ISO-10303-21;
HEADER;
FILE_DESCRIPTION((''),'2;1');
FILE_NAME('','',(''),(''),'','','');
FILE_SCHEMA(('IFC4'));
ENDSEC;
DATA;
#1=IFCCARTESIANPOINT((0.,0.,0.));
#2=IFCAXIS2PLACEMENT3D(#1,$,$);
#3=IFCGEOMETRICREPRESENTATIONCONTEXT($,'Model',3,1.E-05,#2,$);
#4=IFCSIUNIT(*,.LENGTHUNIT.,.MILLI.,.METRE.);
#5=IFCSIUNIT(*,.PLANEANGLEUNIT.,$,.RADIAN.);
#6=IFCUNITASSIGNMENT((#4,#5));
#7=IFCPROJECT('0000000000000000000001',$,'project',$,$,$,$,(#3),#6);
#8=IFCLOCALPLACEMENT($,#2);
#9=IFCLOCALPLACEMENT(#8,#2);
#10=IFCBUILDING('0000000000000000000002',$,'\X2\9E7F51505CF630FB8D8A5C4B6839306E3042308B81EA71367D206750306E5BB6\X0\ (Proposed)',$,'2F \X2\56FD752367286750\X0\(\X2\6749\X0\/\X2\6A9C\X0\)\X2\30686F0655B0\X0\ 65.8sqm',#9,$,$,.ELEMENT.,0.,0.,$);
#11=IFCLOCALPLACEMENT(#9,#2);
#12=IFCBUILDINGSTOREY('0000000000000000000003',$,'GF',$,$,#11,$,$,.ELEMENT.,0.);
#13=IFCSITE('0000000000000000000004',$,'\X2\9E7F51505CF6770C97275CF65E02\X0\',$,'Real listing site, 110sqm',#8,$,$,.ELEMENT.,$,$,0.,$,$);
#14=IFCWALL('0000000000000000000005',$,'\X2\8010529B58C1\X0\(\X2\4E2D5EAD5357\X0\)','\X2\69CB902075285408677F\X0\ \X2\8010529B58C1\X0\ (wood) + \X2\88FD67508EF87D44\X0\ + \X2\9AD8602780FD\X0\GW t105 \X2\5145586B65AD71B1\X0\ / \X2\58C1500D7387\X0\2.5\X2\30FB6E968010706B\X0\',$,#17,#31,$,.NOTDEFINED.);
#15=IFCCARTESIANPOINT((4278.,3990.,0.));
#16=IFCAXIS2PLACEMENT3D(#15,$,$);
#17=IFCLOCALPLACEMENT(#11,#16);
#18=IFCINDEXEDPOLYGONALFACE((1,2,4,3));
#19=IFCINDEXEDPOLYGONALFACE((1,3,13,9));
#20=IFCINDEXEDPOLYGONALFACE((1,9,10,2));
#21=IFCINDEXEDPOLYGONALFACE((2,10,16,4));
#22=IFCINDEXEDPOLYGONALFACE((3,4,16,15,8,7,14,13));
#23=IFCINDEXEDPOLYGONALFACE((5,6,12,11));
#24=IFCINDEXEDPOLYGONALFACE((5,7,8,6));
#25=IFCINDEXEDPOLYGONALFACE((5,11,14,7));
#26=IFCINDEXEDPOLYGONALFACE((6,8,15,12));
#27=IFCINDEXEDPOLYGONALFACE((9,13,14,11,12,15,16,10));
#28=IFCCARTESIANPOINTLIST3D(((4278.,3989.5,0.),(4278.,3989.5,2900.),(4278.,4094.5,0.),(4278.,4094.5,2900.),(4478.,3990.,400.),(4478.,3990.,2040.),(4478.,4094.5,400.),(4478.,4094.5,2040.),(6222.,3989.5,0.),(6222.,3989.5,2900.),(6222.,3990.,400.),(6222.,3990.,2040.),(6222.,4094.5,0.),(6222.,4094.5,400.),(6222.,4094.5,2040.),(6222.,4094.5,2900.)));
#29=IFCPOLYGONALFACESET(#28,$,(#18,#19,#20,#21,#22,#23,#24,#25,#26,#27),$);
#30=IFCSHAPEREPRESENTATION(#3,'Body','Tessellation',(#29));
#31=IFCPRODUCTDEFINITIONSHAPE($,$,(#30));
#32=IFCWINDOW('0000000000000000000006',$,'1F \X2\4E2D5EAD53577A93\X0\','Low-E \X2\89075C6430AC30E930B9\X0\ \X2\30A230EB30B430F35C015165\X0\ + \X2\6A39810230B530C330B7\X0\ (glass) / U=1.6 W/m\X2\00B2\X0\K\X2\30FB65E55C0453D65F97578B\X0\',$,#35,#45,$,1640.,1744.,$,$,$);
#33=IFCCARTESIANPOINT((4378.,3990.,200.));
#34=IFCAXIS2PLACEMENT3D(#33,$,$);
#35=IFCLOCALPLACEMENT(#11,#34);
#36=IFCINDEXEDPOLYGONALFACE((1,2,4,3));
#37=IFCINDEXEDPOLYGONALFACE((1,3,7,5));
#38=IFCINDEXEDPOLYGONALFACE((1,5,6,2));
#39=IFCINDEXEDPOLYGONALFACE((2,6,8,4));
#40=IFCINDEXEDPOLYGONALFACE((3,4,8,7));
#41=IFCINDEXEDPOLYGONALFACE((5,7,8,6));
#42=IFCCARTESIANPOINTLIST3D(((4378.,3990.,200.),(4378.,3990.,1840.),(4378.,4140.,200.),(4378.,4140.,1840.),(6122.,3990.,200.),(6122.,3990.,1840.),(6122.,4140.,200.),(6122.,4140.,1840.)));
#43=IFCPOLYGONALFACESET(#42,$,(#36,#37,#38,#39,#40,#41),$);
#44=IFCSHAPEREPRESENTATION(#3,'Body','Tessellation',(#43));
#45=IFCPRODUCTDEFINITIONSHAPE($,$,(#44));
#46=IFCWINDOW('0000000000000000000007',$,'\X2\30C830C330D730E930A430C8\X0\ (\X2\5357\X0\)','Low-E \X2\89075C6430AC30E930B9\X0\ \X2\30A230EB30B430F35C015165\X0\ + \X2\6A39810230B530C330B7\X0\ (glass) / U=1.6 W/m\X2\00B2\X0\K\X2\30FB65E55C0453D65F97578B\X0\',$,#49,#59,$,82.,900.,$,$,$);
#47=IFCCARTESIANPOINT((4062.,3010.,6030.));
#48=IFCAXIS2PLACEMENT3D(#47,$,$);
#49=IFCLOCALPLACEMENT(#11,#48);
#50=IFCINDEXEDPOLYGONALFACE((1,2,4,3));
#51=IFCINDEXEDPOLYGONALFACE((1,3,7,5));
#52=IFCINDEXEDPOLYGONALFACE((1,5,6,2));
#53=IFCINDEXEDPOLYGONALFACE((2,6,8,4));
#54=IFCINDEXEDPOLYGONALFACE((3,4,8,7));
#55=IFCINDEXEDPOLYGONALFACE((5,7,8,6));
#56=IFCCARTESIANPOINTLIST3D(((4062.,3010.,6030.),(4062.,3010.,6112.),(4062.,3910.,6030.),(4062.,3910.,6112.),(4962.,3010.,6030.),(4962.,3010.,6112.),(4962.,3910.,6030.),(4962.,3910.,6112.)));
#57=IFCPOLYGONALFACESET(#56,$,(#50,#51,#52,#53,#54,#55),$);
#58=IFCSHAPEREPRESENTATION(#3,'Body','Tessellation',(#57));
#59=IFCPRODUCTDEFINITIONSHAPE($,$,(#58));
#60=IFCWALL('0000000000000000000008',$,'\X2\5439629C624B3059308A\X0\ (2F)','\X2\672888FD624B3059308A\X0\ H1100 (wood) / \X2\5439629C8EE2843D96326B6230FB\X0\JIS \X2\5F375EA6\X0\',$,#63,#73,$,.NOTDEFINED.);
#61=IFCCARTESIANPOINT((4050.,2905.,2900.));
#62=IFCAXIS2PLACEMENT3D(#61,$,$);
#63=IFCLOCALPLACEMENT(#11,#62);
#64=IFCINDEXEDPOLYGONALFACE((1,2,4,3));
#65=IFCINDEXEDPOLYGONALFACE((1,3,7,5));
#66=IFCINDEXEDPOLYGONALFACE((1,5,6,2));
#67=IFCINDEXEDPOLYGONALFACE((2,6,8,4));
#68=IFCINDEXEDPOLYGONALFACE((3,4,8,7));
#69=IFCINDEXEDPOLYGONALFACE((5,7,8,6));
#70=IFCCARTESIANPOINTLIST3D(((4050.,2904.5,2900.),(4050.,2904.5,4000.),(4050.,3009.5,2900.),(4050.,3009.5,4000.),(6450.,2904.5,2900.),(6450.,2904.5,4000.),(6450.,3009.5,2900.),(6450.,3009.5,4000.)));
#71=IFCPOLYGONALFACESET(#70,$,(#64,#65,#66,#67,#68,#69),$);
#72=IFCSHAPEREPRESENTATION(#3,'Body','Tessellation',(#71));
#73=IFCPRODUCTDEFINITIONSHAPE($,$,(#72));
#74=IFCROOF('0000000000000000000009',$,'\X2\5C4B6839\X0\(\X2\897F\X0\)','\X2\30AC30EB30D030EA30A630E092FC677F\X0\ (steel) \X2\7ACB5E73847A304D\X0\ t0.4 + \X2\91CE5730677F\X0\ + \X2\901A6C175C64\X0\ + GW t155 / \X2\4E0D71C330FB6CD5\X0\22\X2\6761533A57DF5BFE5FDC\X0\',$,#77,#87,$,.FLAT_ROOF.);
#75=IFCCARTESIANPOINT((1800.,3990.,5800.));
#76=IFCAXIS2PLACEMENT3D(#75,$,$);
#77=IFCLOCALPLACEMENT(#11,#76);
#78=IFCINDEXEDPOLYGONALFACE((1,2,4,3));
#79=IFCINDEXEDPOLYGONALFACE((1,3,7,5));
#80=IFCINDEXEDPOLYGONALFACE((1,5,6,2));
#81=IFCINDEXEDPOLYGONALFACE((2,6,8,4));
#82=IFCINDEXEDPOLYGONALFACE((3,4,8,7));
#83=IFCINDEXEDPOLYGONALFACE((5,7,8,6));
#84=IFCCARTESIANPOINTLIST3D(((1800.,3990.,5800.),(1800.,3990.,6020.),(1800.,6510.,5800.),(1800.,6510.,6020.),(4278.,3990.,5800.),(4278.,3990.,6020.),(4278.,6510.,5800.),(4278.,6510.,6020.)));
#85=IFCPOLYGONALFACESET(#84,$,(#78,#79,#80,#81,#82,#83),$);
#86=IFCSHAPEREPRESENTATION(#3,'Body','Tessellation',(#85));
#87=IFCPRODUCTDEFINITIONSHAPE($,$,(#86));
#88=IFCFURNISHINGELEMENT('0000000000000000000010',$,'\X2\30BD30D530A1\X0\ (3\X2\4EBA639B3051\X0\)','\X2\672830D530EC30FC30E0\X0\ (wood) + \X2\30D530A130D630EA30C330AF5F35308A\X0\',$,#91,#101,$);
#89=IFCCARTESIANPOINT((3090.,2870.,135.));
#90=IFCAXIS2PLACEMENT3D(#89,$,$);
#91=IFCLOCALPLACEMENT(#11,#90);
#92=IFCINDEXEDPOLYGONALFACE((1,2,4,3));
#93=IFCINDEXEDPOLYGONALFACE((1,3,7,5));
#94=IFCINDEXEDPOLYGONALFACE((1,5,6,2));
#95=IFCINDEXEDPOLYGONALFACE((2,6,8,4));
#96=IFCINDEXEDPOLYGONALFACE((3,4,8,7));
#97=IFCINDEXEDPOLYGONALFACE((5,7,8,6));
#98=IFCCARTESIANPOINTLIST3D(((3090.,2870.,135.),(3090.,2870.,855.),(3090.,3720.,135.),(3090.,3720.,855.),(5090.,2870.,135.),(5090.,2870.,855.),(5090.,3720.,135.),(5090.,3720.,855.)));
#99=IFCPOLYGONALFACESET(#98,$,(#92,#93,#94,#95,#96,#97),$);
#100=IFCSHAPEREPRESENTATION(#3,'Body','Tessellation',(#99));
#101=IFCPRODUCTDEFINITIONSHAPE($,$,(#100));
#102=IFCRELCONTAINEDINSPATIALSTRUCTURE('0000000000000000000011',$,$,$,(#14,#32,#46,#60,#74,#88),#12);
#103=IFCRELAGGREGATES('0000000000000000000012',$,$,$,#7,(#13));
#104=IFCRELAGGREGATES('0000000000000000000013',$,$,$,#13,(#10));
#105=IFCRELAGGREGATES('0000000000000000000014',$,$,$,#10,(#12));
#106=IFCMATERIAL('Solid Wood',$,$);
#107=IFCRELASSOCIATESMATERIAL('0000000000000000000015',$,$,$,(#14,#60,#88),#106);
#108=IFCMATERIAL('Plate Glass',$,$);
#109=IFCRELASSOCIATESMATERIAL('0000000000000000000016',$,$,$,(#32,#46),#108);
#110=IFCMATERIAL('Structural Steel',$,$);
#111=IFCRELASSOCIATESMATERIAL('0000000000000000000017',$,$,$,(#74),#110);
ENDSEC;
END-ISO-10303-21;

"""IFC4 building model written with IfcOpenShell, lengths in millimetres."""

from ifc_helpers import new_model, si_unit, frame, frame_2d, origin, place, context, project, spatial, rectangle, extrude, material, element, fill, save


model = new_model("IFC4")

# Units and contexts
model_context = context("Model", 3, precision=1e-05, world=origin())
ifc_project = project(units=[si_unit("LENGTHUNIT", "METRE", prefix="MILLI"), si_unit("PLANEANGLEUNIT", "RADIAN")], contexts=[model_context])

# Site, building, storey
site_placement = place(None, origin())
site = spatial("IfcSite", under=ifc_project, at=site_placement, Name="鹿児島県霧島市", ObjectType="Real listing site, 110sqm", CompositionType="ELEMENT", RefElevation=0.0)
building_placement = place(site_placement, origin())
building = spatial("IfcBuilding", under=site, at=building_placement, Name="鹿児島・越屋根のある自然素材の家 (Proposed)", ObjectType="2F 国産木材(杉/檜)と漆喰 65.8sqm", CompositionType="ELEMENT", ElevationOfRefHeight=0.0, ElevationOfTerrain=0.0)
storey_placement = place(building_placement, origin())
storey = spatial("IfcBuildingStorey", under=building, at=storey_placement, Name="GF", CompositionType="ELEMENT", Elevation=0.0)

# Shared definitions
ifc_material_1 = material(Name="Solid Wood")

# Wall, opening, window
wall_1_placement = place(storey_placement, frame((4278.0, 3990.0, 0.0)))
wall_1 = element("IfcWall", 1, at=wall_1_placement, inside=storey, material=ifc_material_1, Name="耐力壁(中庭南)", Description="構造用合板 耐力壁 (wood) + 製材軸組 + 高性能GW t105 充填断熱 / 壁倍率2.5・準耐火", PredefinedType="NOTDEFINED", context=model_context, shape_type="SweptSolid", body=[
    extrude(rectangle(XDim=1944.0, YDim=105.0, at=frame_2d((972.0, 52.0))), frame((4278.0, 3990.0, 0.0)), (0.0, 0.0, 1.0), 2900.0),
])
opening_placement = place(storey_placement, frame((4378.0, 3990.0, 200.0)))
opening = element("IfcOpeningElement", 2, at=opening_placement, cuts=wall_1, PredefinedType="NOTDEFINED", context=model_context, shape_type="SweptSolid", body=[
    extrude(rectangle(XDim=1744.0, YDim=150.0, at=frame_2d((872.0, 75.0))), frame((4378.0, 3990.0, 200.0)), (0.0, 0.0, 1.0), 1640.0),
])
ifc_material_2 = material(Name="Plate Glass")
window_1_placement = place(storey_placement, frame((4378.0, 3990.0, 200.0)))
window_1 = element("IfcWindow", 3, at=window_1_placement, inside=storey, material=ifc_material_2, Name="1F 中庭南窓", Description="Low-E 複層ガラス アルゴン封入 + 樹脂サッシ (glass) / U=1.6 W/m²K・日射取得型", OverallHeight=1640.0, OverallWidth=1744.0, context=model_context, shape_type="SweptSolid", body=[
    extrude(rectangle(XDim=1744.0, YDim=150.0, at=frame_2d((872.0, 75.0))), frame((4378.0, 3990.0, 200.0)), (0.0, 0.0, 1.0), 1640.0),
])
fill(opening, window_1)

# Window
window_2_placement = place(storey_placement, frame((4062.0, 3010.0, 6030.0)))
element("IfcWindow", 4, at=window_2_placement, inside=storey, material=ifc_material_2, Name="トップライト (南)", Description="Low-E 複層ガラス アルゴン封入 + 樹脂サッシ (glass) / U=1.6 W/m²K・日射取得型", OverallHeight=82.0, OverallWidth=900.0, context=model_context, shape_type="SweptSolid", body=[
    extrude(rectangle(XDim=900.0, YDim=900.0, at=frame_2d((450.0, 450.0))), frame((4062.0, 3010.0, 6030.0)), (0.0, 0.0, 1.0), 82.0),
])

# Wall
wall_2_placement = place(storey_placement, frame((4050.0, 2905.0, 2900.0)))
element("IfcWall", 5, at=wall_2_placement, inside=storey, material=ifc_material_1, Name="吹抜手すり (2F)", Description="木製手すり H1100 (wood) / 吹抜転落防止・JIS 強度", PredefinedType="NOTDEFINED", context=model_context, shape_type="SweptSolid", body=[
    extrude(rectangle(XDim=2400.0, YDim=105.0, at=frame_2d((1200.0, 52.0))), frame((4050.0, 2905.0, 2900.0)), (0.0, 0.0, 1.0), 1100.0),
])

# Roof
ifc_material_3 = material(Name="Structural Steel")
for number, where, name in (
    (6, (1800.0, 3990.0, 5800.0), "屋根(西)"),
):
    element("IfcRoof", number, at=place(storey_placement, frame(where)), inside=storey, material=ifc_material_3, Name=name, Description="ガルバリウム鋼板 (steel) 立平葺き t0.4 + 野地板 + 通気層 + GW t155 / 不燃・法22条区域対応", PredefinedType="FLAT_ROOF", context=model_context, shape_type="SweptSolid", body=[
        extrude(rectangle(XDim=2478.0, YDim=2520.0, at=frame_2d((1239.0, 1260.0))), frame((1800.0, 3990.0, 5800.0)), (0.0, 0.0, 1.0), 220.0),
    ])

# Furnishing element
furnishing_placement = place(storey_placement, frame((3090.0, 2870.0, 135.0)))
element("IfcFurnishingElement", 7, at=furnishing_placement, inside=storey, material=ifc_material_1, Name="ソファ (3人掛け)", Description="木フレーム (wood) + ファブリック張り", context=model_context, shape_type="SweptSolid", body=[
    extrude(rectangle(XDim=2000.0, YDim=850.0, at=frame_2d((1000.0, 425.0))), frame((3090.0, 2870.0, 135.0)), (0.0, 0.0, 1.0), 720.0),
])

save(model, "model.ifc")
